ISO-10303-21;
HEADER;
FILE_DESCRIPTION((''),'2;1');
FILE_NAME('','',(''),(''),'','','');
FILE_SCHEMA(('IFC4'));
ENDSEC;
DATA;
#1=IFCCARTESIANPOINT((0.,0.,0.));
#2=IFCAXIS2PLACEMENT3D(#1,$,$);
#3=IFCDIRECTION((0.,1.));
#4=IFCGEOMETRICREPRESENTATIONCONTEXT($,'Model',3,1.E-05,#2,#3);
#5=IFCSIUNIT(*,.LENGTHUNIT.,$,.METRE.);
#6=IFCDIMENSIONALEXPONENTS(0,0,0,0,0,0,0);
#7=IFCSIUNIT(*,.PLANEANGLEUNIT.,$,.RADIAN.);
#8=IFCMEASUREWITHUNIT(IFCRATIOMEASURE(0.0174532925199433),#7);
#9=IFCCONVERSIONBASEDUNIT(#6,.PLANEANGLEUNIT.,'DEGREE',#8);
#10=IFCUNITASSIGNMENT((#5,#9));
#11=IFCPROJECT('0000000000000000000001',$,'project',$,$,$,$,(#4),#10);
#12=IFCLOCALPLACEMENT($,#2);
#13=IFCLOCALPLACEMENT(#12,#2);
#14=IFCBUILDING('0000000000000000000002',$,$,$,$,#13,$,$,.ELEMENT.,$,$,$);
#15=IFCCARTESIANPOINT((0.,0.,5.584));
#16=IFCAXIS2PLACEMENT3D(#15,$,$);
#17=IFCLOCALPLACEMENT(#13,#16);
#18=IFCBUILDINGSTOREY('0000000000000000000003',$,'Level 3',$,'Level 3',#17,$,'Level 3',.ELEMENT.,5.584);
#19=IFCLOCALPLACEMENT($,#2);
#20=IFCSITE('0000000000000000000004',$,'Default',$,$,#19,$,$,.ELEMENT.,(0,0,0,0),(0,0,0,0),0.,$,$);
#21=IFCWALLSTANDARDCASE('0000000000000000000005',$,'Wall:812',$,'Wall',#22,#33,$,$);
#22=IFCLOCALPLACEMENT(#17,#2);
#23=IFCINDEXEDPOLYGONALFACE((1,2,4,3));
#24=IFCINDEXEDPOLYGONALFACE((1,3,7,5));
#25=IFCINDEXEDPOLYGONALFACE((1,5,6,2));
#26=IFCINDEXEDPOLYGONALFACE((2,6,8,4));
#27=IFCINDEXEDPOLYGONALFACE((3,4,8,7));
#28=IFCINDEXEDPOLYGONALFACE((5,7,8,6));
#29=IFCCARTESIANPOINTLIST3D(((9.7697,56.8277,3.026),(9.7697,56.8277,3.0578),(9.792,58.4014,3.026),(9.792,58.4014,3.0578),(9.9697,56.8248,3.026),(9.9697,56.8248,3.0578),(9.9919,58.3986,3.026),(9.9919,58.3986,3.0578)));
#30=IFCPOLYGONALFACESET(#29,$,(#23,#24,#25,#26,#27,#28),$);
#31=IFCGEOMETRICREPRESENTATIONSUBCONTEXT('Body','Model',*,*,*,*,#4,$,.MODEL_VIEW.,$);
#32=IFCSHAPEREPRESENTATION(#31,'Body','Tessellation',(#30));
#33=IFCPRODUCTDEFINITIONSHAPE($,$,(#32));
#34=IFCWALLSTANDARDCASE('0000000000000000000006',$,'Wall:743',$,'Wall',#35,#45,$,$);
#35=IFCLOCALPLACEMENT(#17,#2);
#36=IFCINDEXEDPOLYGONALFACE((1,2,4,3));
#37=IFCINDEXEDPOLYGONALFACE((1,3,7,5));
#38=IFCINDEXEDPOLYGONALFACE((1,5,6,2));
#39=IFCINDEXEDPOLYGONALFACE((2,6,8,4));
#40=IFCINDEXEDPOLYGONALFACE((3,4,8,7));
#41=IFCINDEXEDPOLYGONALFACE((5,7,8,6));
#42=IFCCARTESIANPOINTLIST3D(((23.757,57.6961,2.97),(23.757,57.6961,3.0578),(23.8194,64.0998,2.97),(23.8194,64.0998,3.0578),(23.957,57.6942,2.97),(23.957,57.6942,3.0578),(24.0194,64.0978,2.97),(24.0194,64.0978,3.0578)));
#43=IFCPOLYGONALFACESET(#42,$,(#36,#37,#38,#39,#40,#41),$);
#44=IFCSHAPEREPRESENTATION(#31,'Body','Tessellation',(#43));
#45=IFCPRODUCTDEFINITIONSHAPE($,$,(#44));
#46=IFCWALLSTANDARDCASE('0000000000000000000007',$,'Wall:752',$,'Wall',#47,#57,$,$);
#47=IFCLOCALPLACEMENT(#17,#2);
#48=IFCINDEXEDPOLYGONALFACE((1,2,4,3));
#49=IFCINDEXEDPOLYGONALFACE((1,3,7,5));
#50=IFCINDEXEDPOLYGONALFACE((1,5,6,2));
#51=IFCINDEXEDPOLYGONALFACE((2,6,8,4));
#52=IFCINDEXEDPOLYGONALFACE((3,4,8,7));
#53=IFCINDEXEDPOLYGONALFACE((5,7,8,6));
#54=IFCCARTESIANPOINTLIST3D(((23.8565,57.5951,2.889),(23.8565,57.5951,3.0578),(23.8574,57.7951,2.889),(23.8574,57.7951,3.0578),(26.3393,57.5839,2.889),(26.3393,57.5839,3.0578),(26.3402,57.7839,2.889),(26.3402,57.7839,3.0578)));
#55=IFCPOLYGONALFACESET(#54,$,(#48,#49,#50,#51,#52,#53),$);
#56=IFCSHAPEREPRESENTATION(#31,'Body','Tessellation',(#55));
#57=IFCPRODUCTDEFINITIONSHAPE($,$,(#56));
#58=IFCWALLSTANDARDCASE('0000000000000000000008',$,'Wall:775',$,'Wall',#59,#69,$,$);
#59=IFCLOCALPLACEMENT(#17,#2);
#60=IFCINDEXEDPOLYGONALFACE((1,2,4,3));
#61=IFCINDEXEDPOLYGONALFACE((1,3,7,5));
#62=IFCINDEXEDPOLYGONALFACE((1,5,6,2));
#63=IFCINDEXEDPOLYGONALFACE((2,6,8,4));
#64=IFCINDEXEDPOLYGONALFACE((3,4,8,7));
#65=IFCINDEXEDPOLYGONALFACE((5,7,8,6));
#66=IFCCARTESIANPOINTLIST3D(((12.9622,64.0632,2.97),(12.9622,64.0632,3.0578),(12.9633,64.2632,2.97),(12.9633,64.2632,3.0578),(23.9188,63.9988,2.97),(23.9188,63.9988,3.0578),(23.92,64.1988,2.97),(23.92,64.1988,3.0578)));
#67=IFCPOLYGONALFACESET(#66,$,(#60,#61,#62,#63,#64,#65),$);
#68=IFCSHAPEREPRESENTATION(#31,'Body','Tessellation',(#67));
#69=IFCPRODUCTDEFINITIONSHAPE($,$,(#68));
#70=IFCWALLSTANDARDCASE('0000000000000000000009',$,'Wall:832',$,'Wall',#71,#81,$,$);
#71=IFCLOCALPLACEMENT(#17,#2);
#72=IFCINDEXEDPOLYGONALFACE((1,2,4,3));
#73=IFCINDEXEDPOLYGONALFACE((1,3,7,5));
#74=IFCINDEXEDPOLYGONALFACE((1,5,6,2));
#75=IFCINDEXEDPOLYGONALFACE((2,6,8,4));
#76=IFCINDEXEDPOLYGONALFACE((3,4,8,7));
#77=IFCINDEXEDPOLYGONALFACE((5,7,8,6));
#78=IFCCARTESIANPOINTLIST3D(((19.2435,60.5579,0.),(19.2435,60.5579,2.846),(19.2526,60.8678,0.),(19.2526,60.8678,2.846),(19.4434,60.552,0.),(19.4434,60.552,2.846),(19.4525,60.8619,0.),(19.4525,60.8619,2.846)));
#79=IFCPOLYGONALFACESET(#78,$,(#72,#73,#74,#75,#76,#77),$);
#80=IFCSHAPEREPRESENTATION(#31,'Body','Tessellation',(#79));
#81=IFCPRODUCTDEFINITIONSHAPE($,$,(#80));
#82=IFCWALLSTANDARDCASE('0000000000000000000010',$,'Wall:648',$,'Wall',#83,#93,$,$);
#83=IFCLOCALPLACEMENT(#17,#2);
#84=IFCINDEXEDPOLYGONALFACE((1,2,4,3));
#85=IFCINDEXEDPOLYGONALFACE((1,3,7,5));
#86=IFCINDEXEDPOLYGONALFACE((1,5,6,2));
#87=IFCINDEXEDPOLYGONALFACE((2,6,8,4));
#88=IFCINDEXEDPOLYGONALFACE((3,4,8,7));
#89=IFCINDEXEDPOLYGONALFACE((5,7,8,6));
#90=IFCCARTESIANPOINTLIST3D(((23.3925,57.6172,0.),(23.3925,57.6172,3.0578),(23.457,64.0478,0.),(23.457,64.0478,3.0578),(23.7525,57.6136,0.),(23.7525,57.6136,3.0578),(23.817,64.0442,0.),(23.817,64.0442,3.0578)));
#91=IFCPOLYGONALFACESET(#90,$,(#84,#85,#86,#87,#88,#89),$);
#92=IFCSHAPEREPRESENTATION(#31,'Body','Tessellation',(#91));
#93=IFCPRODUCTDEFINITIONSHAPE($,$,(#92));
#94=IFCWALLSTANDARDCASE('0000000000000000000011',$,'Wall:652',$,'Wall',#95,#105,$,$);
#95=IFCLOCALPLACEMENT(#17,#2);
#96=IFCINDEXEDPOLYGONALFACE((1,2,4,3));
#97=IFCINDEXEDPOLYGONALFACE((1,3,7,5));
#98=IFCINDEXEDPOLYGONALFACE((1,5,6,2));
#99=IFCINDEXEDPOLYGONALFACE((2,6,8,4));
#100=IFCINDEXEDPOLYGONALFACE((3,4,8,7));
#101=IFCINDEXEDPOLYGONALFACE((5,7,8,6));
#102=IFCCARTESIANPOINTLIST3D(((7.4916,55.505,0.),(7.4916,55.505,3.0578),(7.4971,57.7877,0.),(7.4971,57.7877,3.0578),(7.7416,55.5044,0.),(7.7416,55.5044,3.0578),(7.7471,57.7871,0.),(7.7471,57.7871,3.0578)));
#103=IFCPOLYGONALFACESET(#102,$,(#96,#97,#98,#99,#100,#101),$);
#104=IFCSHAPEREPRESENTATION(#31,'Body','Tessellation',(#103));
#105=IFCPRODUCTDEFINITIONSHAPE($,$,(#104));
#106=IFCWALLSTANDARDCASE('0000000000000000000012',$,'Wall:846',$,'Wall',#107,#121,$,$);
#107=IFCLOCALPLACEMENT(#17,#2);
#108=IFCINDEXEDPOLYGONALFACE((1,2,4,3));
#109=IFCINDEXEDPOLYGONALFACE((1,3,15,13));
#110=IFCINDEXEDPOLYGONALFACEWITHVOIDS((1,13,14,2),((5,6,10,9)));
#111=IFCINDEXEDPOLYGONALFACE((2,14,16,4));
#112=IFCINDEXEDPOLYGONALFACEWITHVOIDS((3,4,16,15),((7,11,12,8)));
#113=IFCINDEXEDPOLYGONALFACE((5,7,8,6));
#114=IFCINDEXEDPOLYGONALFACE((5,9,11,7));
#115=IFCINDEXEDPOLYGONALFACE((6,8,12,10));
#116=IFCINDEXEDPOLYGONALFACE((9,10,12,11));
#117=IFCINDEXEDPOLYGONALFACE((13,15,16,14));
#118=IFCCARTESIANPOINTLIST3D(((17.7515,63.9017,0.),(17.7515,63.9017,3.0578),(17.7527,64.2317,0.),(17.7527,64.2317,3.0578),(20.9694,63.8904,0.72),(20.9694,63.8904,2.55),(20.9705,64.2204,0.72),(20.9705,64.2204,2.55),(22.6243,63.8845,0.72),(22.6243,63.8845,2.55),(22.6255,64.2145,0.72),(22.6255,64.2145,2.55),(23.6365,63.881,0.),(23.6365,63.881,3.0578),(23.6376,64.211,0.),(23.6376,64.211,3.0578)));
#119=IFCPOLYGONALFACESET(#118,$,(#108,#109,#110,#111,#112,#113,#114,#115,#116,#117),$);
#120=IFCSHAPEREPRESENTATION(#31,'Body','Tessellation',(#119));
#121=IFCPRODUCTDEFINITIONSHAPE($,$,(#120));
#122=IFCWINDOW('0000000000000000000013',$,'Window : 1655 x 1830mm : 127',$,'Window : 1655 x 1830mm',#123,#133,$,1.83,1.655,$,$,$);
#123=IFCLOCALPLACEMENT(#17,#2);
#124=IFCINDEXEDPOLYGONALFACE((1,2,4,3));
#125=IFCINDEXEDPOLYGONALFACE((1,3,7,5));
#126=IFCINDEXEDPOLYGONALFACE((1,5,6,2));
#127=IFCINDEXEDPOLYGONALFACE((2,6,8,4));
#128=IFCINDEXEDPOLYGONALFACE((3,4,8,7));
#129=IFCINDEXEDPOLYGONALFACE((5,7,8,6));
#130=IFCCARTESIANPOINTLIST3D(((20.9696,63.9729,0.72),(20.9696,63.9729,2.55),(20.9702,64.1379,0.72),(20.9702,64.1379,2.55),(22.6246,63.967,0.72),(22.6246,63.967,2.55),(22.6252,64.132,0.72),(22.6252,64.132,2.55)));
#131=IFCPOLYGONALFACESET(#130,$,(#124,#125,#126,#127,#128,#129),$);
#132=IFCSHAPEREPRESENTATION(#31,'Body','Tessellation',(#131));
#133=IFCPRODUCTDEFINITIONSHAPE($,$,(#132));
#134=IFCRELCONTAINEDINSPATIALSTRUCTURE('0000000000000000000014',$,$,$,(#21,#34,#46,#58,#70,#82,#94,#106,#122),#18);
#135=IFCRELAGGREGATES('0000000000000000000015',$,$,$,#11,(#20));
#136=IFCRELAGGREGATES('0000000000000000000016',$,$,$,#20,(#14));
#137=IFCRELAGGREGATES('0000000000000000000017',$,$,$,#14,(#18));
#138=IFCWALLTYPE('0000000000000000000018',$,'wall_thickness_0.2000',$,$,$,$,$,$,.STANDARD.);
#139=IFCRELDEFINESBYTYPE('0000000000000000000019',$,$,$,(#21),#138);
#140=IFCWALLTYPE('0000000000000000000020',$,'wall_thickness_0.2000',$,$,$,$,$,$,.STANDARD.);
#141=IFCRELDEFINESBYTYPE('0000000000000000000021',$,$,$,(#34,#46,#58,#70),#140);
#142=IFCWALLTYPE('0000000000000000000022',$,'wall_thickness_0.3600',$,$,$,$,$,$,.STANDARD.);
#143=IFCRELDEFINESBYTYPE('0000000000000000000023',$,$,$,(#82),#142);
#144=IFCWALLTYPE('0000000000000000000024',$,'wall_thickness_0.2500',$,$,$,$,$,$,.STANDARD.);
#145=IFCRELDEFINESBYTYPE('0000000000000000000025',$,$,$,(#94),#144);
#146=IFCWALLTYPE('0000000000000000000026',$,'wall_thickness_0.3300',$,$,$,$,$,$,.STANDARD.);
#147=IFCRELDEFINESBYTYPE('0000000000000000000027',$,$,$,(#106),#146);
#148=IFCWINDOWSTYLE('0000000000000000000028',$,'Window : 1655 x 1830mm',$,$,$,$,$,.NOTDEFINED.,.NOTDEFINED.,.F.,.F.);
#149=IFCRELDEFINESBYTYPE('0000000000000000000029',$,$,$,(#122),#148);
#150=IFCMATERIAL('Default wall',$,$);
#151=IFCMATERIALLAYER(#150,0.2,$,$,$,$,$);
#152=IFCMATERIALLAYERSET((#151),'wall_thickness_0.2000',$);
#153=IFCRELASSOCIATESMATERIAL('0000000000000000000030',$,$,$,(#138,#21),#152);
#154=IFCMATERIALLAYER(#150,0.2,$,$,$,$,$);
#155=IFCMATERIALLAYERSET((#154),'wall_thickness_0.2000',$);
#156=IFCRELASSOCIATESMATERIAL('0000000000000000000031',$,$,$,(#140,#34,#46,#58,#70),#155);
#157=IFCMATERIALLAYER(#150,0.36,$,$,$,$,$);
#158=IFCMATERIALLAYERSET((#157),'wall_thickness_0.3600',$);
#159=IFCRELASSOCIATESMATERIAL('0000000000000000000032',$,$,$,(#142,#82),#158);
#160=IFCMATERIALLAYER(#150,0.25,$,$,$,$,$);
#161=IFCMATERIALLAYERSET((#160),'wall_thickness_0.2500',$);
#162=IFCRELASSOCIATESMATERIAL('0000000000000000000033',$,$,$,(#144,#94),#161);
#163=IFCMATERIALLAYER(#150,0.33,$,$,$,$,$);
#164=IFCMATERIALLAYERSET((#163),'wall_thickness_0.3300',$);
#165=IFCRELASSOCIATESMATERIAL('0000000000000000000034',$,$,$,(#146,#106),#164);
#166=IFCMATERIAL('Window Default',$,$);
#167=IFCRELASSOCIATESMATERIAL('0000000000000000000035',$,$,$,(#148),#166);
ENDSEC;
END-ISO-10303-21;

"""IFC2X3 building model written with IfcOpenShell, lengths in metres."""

from ifc_helpers import new_model, entity, si_unit, converted_unit, direction, frame, frame_2d, origin, origin_2d_with_axis, place, context, subcontext, project, spatial, polyline, rectangle, outline, extrude, source, transform, mapped, material, layer, layer_set, layer_usage, type_object, type_shapes, element, fill, save


model = new_model("IFC2X3")

# Units and contexts
model_context = context("Model", 3, precision=1e-05, world=origin(), true_north=direction((0.0, 1.0)))
body_context = subcontext(model_context, "Body", "Model", "MODEL_VIEW")
ifc_project = project(units=[si_unit("LENGTHUNIT", "METRE"), converted_unit("PLANEANGLEUNIT", "DEGREE", entity("IfcRatioMeasure", 0.0174532925199433), si_unit("PLANEANGLEUNIT", "RADIAN"), dimensions=[0, 0, 0, 0, 0, 0, 0])], contexts=[model_context])

# Site, building, storey
site_placement = place(None, origin())
site = spatial("IfcSite", under=ifc_project, at=site_placement, Name="Default", CompositionType="ELEMENT", RefLatitude=(0, 0, 0, 0), RefLongitude=(0, 0, 0, 0), RefElevation=0.0)
placement_1 = place(None, origin())
building_placement = place(placement_1, origin())
building = spatial("IfcBuilding", under=site, at=building_placement, CompositionType="ELEMENT")
storey_placement = place(building_placement, frame((0.0, 0.0, 5.584)))
storey = spatial("IfcBuildingStorey", under=building, at=storey_placement, Name="Level 3", ObjectType="Level 3", LongName="Level 3", CompositionType="ELEMENT", Elevation=5.584)

# Walls
ifc_material_1 = material(Name="Default wall")
ifc_layer_1 = layer(ifc_material_1, 0.2)
ifc_layer_set_1 = layer_set([ifc_layer_1], Name="wall_thickness_0.2000")
ifc_layer_usage_1 = layer_usage(ifc_layer_set_1, "AXIS2", "POSITIVE", -0.1)
wall_type_1 = type_object("IfcWallType", Name="wall_thickness_0.2000", PredefinedType="STANDARD", material=ifc_layer_set_1)
placement_2 = place(building_placement, frame((0.0, 0.0, 8.61)))
wall_1_placement = place(placement_2, frame((9.8919, 58.4, 0.0), z_axis=(0.0, 0.0, 1.0), x_axis=(-0.014108, -0.9999, 0.0)))
element("IfcWallStandardCase", 1, at=wall_1_placement, inside=storey, type_object=wall_type_1, material=ifc_layer_usage_1, Name="Wall:812", ObjectType="Wall", context=body_context, shape_type="SweptSolid", body=[
    extrude(outline(polyline([(1.5739, -0.1), (1.5739, 0.1), (0.0, 0.1), (0.0, -0.1), (1.5739, -0.1)])), origin(), (0.0, 0.0, 1.0), 0.0318),
])
ifc_layer_2 = layer(ifc_material_1, 0.2)
ifc_layer_set_2 = layer_set([ifc_layer_2], Name="wall_thickness_0.2000")
ifc_layer_usage_2 = layer_usage(ifc_layer_set_2, "AXIS2", "POSITIVE", -0.1)
wall_type_2 = type_object("IfcWallType", Name="wall_thickness_0.2000", PredefinedType="STANDARD", material=ifc_layer_set_2)
placement_3 = place(building_placement, frame((0.0, 0.0, 8.554)))
wall_2_placement = place(placement_3, frame((23.9194, 64.0988, 0.0), z_axis=(0.0, 0.0, 1.0), x_axis=(-0.009743, -0.999953, 0.0)))
element("IfcWallStandardCase", 2, at=wall_2_placement, inside=storey, type_object=wall_type_2, material=ifc_layer_usage_2, Name="Wall:743", ObjectType="Wall", context=body_context, shape_type="SweptSolid", body=[
    extrude(outline(polyline([(6.404, -0.1), (6.404, 0.1), (0.0, 0.1), (0.0, -0.1), (6.404, -0.1)])), origin(), (0.0, 0.0, 1.0), 0.0878),
])
placement_4 = place(building_placement, frame((0.0, 0.0, 8.473)))
wall_3_placement = place(placement_4, frame((23.857, 57.6951, 0.0), z_axis=(0.0, 0.0, 1.0), x_axis=(0.99999, -0.004519, 0.0)))
element("IfcWallStandardCase", 3, at=wall_3_placement, inside=storey, type_object=wall_type_2, material=ifc_layer_usage_2, Name="Wall:752", ObjectType="Wall", context=body_context, shape_type="SweptSolid", body=[
    extrude(outline(polyline([(2.4827, -0.1), (2.4827, 0.1), (0.0, 0.1), (0.0, -0.1), (2.4827, -0.1)])), origin(), (0.0, 0.0, 1.0), 0.1688),
])
placement_5 = place(building_placement, frame((0.0, 0.0, 8.554)))
wall_4_placement = place(placement_5, frame((12.9628, 64.1632, 0.0), z_axis=(0.0, 0.0, 1.0), x_axis=(0.999983, -0.005874, 0.0)))
element("IfcWallStandardCase", 4, at=wall_4_placement, inside=storey, type_object=wall_type_2, material=ifc_layer_usage_2, Name="Wall:775", ObjectType="Wall", context=body_context, shape_type="SweptSolid", body=[
    extrude(outline(polyline([(10.9568, -0.1), (10.9568, 0.1), (0.0, 0.1), (0.0, -0.1), (10.9568, -0.1)])), origin(), (0.0, 0.0, 1.0), 0.0878),
])
wall_5_placement = place(storey_placement, frame((19.3525, 60.8648, 0.0), z_axis=(0.0, 0.0, 1.0), x_axis=(-0.029305, -0.999571, 0.0)))
element("IfcWallStandardCase", 5, at=wall_5_placement, inside=storey, type_object=wall_type_2, material=ifc_layer_usage_2, Name="Wall:832", ObjectType="Wall", context=body_context, shape_type="SweptSolid", body=[
    extrude(outline(polyline([(0.31, -0.1), (0.31, 0.1), (0.0, 0.1), (0.0, -0.1), (0.31, -0.1)])), origin(), (0.0, 0.0, 1.0), 2.846),
])
ifc_layer_3 = layer(ifc_material_1, 0.36)
ifc_layer_set_3 = layer_set([ifc_layer_3], Name="wall_thickness_0.3600")
ifc_layer_usage_3 = layer_usage(ifc_layer_set_3, "AXIS2", "POSITIVE", -0.18)
wall_type_3 = type_object("IfcWallType", Name="wall_thickness_0.3600", PredefinedType="STANDARD", material=ifc_layer_set_3)
wall_6_placement = place(storey_placement, frame((23.637, 64.046, 0.0), z_axis=(0.0, 0.0, 1.0), x_axis=(-0.01004, -0.99995, 0.0)))
element("IfcWallStandardCase", 6, at=wall_6_placement, inside=storey, type_object=wall_type_3, material=ifc_layer_usage_3, Name="Wall:648", ObjectType="Wall", context=body_context, shape_type="SweptSolid", body=[
    extrude(outline(polyline([(6.4309, -0.18), (6.4309, 0.18), (0.0, 0.18), (0.0, -0.18), (6.4309, -0.18)])), origin(), (0.0, 0.0, 1.0), 3.0578),
])
ifc_layer_4 = layer(ifc_material_1, 0.25)
ifc_layer_set_4 = layer_set([ifc_layer_4], Name="wall_thickness_0.2500")
ifc_layer_usage_4 = layer_usage(ifc_layer_set_4, "AXIS2", "POSITIVE", -0.125)
wall_type_4 = type_object("IfcWallType", Name="wall_thickness_0.2500", PredefinedType="STANDARD", material=ifc_layer_set_4)
wall_7_placement = place(storey_placement, frame((7.6221, 57.7874, 0.0), z_axis=(0.0, 0.0, 1.0), x_axis=(-0.002424, -0.999997, 0.0)))
element("IfcWallStandardCase", 7, at=wall_7_placement, inside=storey, type_object=wall_type_4, material=ifc_layer_usage_4, Name="Wall:652", ObjectType="Wall", context=body_context, shape_type="SweptSolid", body=[
    extrude(outline(polyline([(2.2826, -0.125), (2.2826, 0.125), (0.0, 0.125), (0.0, -0.125), (2.2826, -0.125)])), origin(), (0.0, 0.0, 1.0), 3.0578),
])

# Wall, opening, window
ifc_layer_5 = layer(ifc_material_1, 0.33)
ifc_layer_set_5 = layer_set([ifc_layer_5], Name="wall_thickness_0.3300")
ifc_layer_usage_5 = layer_usage(ifc_layer_set_5, "AXIS2", "POSITIVE", -0.165)
wall_type_5 = type_object("IfcWallType", Name="wall_thickness_0.3300", PredefinedType="STANDARD", material=ifc_layer_set_5)
wall_8_placement = place(storey_placement, frame((17.7521, 64.0667, 0.0), z_axis=(0.0, 0.0, 1.0), x_axis=(0.999994, -0.00353, 0.0)))
wall_8 = element("IfcWallStandardCase", 8, at=wall_8_placement, inside=storey, type_object=wall_type_5, material=ifc_layer_usage_5, Name="Wall:846", ObjectType="Wall", context=body_context, shape_type="SweptSolid", body=[
    extrude(outline(polyline([(5.8849, -0.165), (5.8849, 0.165), (0.0, 0.165), (0.0, -0.165), (5.8849, -0.165)])), origin(), (0.0, 0.0, 1.0), 3.0578),
])
opening_1_placement = place(wall_8_placement, frame((3.2178, -0.165, 0.72)))
opening_1 = element("IfcOpeningElement", 9, at=opening_1_placement, cuts=wall_8, ObjectType="Opening", context=body_context, shape_type="SweptSolid", body=[
    extrude(rectangle(XDim=1.655, YDim=1.83, at=frame_2d((0.915, 0.8275), x_axis=(0.0, 1.0))), frame((0.0, 0.0, 0.0), z_axis=(0.0, 1.0, 0.0), x_axis=(0.0, 0.0, 1.0)), (0.0, 0.0, 1.0), 0.33),
])
ifc_material_2 = material(Name="Window Default")
window_style_1 = type_object("IfcWindowStyle", Name="Window : 1655 x 1830mm", ConstructionType="NOTDEFINED", OperationType="NOTDEFINED", ParameterTakesPrecedence=False, Sizeable=False, material=ifc_material_2)
shared_shape_1 = source(origin(), body_context, "Body", "SweptSolid", [
    extrude(rectangle(XDim=0.165, YDim=1.655, at=origin_2d_with_axis()), frame((0.8275, 0.165, 0.0), z_axis=(0.0, 0.0, 1.0), x_axis=(0.0, 1.0, 0.0)), (0.0, 0.0, 1.0), 1.83),
])
type_shapes(window_style_1, [shared_shape_1])
window_1_placement = place(opening_1_placement, origin())
window_1 = element("IfcWindow", 10, at=window_1_placement, inside=storey, type_object=window_style_1, Name="Window : 1655 x 1830mm : 127", ObjectType="Window : 1655 x 1830mm", OverallHeight=1.83, OverallWidth=1.655, context=body_context, shape_type="MappedRepresentation", body=[
    mapped(shared_shape_1, transform((0.0, 0.0, 0.0), scale=1.0)),
])
fill(opening_1, window_1)

save(model, "model.ifc")
